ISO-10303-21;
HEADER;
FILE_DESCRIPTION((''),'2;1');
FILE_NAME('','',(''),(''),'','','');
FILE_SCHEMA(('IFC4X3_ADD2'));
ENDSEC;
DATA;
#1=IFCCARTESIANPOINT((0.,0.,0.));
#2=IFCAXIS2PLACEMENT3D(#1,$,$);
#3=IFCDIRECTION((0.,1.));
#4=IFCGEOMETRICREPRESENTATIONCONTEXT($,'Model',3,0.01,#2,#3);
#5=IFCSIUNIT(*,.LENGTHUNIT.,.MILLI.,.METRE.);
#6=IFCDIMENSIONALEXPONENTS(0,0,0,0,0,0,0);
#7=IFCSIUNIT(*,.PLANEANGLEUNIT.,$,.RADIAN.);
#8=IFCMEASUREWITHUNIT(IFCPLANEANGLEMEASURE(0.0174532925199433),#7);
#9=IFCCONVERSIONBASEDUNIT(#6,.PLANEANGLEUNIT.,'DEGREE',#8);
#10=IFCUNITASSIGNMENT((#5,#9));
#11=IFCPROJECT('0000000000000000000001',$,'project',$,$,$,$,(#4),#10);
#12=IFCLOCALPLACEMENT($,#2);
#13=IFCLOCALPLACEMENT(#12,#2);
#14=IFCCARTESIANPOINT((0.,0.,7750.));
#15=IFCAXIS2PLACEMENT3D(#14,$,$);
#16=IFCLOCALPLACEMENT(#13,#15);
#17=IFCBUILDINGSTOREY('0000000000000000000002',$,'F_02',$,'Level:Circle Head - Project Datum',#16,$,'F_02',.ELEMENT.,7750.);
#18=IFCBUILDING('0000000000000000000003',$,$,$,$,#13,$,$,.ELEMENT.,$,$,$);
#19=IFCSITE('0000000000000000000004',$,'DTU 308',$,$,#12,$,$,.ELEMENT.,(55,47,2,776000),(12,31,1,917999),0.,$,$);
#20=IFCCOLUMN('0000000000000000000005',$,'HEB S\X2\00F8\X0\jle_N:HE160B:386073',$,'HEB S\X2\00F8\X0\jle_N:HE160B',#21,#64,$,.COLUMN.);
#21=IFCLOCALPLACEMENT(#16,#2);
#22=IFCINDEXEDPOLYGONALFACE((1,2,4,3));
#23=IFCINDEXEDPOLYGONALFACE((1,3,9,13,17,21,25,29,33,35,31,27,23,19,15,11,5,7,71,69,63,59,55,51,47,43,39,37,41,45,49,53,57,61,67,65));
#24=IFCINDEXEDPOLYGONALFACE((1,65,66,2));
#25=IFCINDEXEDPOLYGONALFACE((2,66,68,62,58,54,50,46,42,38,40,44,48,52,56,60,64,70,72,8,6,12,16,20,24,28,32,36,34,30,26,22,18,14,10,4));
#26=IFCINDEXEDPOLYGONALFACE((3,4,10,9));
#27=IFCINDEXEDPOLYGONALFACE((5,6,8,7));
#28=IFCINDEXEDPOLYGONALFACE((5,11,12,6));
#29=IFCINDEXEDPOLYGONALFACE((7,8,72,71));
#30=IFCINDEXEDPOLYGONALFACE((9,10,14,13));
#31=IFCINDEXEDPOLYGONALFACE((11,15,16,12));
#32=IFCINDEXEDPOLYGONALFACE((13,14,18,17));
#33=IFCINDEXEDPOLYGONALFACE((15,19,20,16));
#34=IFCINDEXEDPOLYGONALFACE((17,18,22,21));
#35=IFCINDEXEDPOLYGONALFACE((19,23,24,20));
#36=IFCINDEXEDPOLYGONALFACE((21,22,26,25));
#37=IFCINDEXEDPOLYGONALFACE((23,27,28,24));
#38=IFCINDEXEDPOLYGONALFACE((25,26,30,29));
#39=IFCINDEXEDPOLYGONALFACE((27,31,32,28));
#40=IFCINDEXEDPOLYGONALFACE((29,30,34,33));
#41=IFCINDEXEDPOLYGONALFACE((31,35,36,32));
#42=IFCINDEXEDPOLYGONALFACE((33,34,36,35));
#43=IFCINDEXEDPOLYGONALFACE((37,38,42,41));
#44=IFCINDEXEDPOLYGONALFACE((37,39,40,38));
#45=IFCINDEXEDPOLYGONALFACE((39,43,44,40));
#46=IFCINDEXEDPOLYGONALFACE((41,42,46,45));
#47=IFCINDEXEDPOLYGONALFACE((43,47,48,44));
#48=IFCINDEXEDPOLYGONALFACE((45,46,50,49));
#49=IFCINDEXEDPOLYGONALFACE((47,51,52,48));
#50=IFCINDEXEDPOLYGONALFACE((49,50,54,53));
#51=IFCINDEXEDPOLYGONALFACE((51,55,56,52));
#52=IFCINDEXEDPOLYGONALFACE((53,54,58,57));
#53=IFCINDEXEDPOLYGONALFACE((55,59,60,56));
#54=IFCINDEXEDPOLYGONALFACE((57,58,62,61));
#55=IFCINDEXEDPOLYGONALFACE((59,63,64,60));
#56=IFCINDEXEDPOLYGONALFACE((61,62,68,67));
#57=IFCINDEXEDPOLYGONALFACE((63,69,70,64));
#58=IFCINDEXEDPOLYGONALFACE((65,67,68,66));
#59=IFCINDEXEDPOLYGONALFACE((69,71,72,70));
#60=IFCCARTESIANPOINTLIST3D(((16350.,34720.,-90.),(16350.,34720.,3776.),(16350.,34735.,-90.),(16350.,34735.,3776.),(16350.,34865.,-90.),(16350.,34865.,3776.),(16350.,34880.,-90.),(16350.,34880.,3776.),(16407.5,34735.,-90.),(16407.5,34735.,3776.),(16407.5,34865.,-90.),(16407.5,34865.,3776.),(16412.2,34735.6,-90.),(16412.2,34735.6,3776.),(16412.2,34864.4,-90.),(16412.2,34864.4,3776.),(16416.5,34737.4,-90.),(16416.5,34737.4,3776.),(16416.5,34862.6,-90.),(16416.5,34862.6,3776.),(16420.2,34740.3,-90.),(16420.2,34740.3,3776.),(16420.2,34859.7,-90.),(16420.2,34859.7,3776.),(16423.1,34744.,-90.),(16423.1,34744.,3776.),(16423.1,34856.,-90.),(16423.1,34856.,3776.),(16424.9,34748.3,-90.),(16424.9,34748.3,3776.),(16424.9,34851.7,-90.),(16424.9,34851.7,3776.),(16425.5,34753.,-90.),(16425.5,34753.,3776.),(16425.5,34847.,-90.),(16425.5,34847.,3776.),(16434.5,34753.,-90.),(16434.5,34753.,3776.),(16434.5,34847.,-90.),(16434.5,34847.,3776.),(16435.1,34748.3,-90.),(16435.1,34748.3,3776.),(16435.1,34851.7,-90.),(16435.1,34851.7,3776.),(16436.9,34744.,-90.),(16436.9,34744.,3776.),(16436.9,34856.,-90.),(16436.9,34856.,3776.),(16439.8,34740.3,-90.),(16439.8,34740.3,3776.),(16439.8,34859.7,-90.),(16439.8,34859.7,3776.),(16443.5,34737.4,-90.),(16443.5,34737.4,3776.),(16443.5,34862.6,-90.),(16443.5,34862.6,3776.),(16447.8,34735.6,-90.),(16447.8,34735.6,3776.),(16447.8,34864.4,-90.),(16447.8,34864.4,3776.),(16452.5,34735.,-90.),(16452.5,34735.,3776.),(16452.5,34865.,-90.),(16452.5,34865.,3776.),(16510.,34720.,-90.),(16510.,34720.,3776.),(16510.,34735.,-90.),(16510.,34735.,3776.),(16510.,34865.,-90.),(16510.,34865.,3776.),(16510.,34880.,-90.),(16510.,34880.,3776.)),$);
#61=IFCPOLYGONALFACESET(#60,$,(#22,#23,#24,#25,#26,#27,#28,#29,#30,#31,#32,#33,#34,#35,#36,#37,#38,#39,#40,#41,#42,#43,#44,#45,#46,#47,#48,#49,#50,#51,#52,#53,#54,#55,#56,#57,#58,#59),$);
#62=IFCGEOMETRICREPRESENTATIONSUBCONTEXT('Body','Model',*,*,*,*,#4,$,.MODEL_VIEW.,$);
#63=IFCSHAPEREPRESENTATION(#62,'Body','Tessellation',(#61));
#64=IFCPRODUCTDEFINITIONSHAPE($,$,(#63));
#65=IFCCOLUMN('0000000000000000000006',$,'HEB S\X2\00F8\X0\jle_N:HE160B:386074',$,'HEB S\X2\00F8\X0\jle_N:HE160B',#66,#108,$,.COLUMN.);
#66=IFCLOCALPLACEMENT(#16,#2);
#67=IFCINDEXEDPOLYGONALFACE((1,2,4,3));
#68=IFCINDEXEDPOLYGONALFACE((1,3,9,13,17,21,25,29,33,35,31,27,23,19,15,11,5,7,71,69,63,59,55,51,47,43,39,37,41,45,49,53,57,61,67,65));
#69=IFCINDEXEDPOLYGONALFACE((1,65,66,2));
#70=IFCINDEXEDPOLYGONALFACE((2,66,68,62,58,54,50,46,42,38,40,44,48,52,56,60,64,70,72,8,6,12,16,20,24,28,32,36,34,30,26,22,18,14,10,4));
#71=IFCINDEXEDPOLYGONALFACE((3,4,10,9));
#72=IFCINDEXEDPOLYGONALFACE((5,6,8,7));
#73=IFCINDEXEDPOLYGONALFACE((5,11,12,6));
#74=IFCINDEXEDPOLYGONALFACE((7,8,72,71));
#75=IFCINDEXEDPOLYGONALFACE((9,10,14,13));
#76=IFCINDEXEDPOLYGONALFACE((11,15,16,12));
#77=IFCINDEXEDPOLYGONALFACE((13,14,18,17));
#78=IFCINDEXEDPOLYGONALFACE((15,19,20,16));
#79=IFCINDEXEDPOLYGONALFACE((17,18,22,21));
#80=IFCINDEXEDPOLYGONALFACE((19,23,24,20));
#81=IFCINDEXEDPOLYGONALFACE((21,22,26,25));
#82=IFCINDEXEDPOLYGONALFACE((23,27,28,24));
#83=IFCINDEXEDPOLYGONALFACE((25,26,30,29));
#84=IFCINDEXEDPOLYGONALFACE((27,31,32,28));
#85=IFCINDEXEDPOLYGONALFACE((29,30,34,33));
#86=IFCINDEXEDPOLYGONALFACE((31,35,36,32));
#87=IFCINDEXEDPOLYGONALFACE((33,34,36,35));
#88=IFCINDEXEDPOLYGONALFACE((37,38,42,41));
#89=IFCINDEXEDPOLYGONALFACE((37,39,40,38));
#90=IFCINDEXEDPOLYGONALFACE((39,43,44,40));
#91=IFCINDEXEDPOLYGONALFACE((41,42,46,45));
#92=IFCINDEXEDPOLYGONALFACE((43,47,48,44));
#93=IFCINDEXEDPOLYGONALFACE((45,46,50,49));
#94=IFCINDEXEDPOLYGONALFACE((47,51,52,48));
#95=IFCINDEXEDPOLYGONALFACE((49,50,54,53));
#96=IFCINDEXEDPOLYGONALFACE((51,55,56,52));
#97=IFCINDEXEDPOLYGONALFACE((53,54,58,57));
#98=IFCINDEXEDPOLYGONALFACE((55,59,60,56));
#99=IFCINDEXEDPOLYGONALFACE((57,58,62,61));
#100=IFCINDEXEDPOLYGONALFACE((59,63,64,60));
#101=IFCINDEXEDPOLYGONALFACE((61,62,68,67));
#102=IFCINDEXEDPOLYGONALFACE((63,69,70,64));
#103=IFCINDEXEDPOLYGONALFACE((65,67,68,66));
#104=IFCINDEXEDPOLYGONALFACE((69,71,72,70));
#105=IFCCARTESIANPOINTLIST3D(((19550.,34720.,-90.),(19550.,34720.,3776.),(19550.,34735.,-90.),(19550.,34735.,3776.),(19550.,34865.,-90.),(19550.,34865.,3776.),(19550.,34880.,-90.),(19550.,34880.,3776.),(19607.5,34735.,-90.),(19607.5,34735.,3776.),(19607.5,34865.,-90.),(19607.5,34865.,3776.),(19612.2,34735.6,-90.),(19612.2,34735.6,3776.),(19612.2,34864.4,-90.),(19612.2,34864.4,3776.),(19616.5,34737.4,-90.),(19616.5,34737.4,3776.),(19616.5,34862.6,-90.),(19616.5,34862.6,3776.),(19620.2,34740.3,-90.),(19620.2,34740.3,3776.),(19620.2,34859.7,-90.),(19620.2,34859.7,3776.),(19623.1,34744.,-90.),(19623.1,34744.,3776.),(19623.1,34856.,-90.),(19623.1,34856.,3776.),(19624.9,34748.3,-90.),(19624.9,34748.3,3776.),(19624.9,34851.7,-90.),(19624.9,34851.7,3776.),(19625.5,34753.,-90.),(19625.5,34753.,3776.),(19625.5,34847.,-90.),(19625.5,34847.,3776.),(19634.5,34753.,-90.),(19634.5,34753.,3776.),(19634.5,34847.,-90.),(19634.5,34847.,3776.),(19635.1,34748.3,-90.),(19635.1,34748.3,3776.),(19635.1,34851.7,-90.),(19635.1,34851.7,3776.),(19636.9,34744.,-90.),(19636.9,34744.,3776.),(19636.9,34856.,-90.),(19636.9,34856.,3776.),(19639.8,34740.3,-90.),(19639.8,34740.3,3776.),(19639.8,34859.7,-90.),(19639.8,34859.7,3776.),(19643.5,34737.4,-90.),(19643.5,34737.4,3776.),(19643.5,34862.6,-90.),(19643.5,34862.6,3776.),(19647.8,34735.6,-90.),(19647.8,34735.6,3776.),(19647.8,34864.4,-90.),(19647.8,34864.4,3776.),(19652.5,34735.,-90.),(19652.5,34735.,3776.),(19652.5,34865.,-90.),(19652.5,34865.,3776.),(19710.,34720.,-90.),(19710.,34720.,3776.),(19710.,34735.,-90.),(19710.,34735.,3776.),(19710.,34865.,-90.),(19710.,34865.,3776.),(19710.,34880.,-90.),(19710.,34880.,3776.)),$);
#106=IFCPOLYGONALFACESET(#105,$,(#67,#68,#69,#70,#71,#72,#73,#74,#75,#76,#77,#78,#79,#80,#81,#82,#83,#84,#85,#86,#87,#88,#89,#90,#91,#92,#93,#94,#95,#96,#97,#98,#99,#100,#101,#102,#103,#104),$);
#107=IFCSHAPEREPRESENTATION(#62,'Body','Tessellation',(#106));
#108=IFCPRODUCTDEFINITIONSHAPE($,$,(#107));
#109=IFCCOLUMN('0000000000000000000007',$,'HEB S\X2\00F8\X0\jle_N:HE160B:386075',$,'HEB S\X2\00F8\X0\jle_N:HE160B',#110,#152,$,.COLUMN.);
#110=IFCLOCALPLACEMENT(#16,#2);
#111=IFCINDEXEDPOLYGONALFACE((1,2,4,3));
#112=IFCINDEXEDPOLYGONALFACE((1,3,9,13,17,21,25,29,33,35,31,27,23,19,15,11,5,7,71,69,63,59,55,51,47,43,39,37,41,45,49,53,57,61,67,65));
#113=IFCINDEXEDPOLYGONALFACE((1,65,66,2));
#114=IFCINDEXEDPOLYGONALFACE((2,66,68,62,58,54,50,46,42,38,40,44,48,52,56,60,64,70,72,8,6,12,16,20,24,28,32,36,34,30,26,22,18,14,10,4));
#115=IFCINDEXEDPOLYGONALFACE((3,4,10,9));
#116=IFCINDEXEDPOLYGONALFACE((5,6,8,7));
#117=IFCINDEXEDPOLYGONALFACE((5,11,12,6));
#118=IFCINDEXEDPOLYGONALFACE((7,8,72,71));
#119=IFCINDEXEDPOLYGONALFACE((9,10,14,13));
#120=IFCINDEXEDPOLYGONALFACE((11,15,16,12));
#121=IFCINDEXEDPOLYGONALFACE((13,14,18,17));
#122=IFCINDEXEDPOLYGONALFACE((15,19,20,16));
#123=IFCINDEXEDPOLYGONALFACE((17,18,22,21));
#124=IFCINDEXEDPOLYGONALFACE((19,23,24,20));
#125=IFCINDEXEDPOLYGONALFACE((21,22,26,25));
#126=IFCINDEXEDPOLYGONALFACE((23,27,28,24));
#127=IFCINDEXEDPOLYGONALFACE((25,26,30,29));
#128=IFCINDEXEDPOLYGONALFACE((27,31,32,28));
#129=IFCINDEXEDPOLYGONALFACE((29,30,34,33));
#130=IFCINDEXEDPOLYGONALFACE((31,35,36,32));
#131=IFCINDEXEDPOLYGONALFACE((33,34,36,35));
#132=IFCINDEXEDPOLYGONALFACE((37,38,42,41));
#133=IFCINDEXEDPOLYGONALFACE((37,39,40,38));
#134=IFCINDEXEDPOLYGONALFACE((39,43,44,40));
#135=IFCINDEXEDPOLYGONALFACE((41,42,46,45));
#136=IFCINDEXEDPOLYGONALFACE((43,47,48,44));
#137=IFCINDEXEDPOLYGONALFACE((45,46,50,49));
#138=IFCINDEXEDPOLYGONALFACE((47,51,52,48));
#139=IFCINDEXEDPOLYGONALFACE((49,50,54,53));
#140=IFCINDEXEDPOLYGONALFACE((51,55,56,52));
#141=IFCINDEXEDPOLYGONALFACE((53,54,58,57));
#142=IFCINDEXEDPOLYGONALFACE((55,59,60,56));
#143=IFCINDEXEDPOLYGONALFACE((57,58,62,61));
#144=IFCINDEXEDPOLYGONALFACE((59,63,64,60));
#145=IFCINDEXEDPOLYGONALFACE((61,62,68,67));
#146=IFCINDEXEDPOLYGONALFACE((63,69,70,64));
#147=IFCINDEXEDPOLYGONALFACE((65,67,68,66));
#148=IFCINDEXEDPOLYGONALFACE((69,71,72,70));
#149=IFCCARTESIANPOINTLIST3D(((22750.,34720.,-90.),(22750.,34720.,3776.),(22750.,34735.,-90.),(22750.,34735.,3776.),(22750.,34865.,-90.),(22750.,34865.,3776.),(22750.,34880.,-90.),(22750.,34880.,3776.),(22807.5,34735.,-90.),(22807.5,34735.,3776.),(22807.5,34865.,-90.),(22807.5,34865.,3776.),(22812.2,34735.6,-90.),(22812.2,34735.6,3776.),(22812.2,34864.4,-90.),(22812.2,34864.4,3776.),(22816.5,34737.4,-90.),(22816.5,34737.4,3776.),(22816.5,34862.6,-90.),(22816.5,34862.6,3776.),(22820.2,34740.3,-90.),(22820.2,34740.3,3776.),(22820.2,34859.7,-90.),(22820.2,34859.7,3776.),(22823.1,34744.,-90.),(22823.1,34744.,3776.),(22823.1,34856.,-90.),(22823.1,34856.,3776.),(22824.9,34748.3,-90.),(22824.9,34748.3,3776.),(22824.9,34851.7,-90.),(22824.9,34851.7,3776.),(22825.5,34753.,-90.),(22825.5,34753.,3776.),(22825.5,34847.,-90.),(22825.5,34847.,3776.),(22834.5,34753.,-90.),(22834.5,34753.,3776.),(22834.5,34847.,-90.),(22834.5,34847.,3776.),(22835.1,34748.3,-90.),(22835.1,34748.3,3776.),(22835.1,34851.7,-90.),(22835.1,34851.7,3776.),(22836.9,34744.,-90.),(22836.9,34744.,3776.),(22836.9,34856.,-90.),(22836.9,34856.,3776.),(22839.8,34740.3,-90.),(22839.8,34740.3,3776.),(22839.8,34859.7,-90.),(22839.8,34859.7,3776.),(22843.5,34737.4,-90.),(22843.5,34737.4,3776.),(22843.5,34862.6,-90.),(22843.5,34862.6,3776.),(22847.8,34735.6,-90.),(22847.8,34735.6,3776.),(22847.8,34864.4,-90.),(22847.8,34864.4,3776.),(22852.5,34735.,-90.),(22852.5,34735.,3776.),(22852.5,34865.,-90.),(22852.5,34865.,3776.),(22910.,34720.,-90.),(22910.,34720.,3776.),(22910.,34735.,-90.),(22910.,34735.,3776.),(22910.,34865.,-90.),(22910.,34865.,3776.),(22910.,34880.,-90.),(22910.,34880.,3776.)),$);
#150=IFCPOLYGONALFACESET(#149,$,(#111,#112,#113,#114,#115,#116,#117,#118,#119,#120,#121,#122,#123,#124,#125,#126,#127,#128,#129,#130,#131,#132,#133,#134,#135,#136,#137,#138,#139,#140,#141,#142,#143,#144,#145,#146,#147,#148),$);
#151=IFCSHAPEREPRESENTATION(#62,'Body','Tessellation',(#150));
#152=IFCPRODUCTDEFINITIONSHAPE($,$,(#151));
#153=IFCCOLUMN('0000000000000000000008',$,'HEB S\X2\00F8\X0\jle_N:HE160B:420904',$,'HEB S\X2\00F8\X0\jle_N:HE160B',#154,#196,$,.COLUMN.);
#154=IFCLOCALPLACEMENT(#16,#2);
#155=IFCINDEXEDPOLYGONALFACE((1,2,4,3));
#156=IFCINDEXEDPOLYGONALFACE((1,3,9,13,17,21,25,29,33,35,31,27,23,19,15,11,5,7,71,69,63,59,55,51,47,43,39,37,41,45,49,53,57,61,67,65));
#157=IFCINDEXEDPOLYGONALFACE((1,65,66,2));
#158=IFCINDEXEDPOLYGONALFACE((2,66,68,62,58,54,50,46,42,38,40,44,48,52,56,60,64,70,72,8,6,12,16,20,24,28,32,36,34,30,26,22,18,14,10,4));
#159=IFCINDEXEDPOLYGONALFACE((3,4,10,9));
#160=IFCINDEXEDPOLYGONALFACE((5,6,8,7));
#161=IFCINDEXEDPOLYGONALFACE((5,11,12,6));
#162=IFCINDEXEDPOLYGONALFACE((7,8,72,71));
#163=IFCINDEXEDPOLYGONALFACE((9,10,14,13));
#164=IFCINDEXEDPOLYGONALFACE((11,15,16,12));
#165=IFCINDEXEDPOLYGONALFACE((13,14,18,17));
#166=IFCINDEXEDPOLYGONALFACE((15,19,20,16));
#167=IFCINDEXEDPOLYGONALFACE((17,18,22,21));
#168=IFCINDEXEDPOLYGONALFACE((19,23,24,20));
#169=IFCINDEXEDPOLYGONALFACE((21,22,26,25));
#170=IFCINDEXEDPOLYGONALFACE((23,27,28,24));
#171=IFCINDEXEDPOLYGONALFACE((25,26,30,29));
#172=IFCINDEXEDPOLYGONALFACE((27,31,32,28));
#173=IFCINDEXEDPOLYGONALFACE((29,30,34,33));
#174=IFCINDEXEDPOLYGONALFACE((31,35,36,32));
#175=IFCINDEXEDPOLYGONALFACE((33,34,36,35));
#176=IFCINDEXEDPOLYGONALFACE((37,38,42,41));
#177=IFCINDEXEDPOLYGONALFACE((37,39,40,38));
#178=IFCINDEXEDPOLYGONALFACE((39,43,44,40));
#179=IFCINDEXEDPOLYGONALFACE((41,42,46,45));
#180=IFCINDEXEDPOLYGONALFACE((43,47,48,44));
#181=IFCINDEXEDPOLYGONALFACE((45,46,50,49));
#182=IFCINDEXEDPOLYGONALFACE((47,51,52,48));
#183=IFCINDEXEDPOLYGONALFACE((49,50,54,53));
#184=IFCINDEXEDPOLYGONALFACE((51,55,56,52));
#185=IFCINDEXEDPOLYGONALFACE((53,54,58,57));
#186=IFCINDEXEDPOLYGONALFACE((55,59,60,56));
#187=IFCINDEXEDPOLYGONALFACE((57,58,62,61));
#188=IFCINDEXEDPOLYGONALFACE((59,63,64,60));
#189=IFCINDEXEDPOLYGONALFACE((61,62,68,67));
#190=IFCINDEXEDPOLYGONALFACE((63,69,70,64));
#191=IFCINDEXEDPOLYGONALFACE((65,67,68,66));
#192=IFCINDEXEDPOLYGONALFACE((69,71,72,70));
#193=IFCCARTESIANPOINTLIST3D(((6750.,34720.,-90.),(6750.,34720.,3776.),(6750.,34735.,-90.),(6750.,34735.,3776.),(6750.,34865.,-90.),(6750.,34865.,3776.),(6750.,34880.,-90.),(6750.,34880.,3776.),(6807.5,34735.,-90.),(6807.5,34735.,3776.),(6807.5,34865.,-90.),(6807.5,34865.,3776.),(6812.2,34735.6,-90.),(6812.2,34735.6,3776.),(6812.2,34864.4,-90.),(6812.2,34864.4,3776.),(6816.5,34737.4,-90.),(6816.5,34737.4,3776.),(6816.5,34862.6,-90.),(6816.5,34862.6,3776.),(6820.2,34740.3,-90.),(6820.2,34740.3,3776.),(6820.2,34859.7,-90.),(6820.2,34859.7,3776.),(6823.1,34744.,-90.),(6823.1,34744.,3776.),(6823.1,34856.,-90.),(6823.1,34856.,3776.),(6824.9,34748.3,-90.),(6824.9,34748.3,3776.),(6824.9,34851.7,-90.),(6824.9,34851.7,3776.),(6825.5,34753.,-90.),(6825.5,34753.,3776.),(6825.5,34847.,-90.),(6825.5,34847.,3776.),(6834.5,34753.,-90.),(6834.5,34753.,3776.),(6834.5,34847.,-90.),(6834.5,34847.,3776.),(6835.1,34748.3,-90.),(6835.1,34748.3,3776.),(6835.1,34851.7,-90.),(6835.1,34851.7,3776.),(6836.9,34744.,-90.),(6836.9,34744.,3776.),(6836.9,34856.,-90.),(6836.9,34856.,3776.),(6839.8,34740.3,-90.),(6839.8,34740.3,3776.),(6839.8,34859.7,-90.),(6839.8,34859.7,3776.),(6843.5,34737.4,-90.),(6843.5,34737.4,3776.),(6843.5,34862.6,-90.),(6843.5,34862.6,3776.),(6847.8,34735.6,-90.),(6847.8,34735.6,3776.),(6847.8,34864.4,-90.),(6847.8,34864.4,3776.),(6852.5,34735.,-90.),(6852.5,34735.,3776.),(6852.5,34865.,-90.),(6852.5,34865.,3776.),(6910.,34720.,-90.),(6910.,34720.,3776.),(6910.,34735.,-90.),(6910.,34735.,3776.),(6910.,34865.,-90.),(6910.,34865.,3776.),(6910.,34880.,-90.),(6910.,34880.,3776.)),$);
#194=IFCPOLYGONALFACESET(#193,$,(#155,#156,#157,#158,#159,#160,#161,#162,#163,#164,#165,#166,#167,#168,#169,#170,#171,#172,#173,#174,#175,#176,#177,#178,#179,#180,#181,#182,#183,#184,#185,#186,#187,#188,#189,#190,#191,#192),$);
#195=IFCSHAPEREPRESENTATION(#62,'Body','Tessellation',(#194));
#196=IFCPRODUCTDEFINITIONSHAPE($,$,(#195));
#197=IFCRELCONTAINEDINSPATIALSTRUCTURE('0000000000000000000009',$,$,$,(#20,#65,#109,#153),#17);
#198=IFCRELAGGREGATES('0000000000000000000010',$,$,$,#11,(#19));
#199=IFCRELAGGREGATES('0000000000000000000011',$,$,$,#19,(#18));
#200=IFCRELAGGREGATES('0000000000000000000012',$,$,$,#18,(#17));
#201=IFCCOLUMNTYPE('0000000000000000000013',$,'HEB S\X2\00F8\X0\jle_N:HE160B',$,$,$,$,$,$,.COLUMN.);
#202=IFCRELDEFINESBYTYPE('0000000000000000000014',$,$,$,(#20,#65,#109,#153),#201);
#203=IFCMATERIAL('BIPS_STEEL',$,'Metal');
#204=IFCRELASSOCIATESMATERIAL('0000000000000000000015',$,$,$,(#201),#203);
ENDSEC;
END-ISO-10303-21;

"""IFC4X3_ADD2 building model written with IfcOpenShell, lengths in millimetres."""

from ifc_helpers import new_model, entity, si_unit, converted_unit, direction, frame, frame_2d, origin, place, context, subcontext, project, spatial, i_section, extrude, source, transform, mapped, material, material_profile, profile_set, type_object, element, save


model = new_model("IFC4X3_ADD2")

# Units and contexts
model_context = context("Model", 3, precision=0.01, world=origin(), true_north=direction((0.0, 1.0)))
body_context = subcontext(model_context, "Body", "Model", "MODEL_VIEW")
ifc_project = project(units=[si_unit("LENGTHUNIT", "METRE", prefix="MILLI"), converted_unit("PLANEANGLEUNIT", "DEGREE", entity("IfcPlaneAngleMeasure", 0.0174532925199433), si_unit("PLANEANGLEUNIT", "RADIAN"), dimensions=[0, 0, 0, 0, 0, 0, 0])], contexts=[model_context])

# Site, building, storey
site_placement = place(None, origin())
site = spatial("IfcSite", under=ifc_project, at=site_placement, Name="DTU 308", CompositionType="ELEMENT", RefLatitude=(55, 47, 2, 776000), RefLongitude=(12, 31, 1, 917999), RefElevation=0.0)
building_placement = place(site_placement, origin())
building = spatial("IfcBuilding", under=site, at=building_placement, CompositionType="ELEMENT")
storey_placement = place(building_placement, frame((0.0, 0.0, 7750.0)))
storey = spatial("IfcBuildingStorey", under=building, at=storey_placement, Name="F_02", ObjectType="Level:Circle Head - Project Datum", LongName="F_02", CompositionType="ELEMENT", Elevation=7750.0)

# Columns
ifc_material = material(Name="BIPS_STEEL", Category="Metal")
ifc_material_profile_1 = material_profile(ifc_material, i_section(OverallWidth=160.0, OverallDepth=160.0, WebThickness=9.0, FlangeThickness=15.0, FilletRadius=18.0, at=frame_2d((0.0, 0.0), x_axis=(1.0, 0.0))), Name="HE160B")
ifc_profile_set_1 = profile_set([ifc_material_profile_1], Name="HE160B")
column_type_1 = type_object("IfcColumnType", Name="HEB Søjle_N:HE160B", PredefinedType="COLUMN", material=ifc_profile_set_1)
shared_shape_1 = source(origin(), body_context, "Body", "SweptSolid", [
    extrude(i_section(OverallWidth=160.0, OverallDepth=160.0, WebThickness=9.0, FlangeThickness=15.0, FilletRadius=18.0, at=frame_2d((0.0, 0.0), x_axis=(1.0, 0.0))), frame((0.0, 0.0, 7660.0), z_axis=(0.0, 0.0, 1.0), x_axis=(-1.0, 0.0, 0.0)), (0.0, 0.0, 1.0), 3866.0),
])
for number, where, name in (
    (1, (16430.0, 34800.0, -7750.0), "HEB Søjle_N:HE160B:386073"),
    (2, (19630.0, 34800.0, -7750.0), "HEB Søjle_N:HE160B:386074"),
    (3, (22830.0, 34800.0, -7750.0), "HEB Søjle_N:HE160B:386075"),
    (4, (6830.0, 34800.0, -7750.0), "HEB Søjle_N:HE160B:420904"),
):
    element("IfcColumn", number, at=place(storey_placement, frame(where)), inside=storey, type_object=column_type_1, Name=name, ObjectType="HEB Søjle_N:HE160B", PredefinedType="COLUMN", context=body_context, shape_type="MappedRepresentation", body=[
        mapped(shared_shape_1, transform((0.0, 0.0, 0.0), scale=1.0)),
    ])

save(model, "model.ifc")
